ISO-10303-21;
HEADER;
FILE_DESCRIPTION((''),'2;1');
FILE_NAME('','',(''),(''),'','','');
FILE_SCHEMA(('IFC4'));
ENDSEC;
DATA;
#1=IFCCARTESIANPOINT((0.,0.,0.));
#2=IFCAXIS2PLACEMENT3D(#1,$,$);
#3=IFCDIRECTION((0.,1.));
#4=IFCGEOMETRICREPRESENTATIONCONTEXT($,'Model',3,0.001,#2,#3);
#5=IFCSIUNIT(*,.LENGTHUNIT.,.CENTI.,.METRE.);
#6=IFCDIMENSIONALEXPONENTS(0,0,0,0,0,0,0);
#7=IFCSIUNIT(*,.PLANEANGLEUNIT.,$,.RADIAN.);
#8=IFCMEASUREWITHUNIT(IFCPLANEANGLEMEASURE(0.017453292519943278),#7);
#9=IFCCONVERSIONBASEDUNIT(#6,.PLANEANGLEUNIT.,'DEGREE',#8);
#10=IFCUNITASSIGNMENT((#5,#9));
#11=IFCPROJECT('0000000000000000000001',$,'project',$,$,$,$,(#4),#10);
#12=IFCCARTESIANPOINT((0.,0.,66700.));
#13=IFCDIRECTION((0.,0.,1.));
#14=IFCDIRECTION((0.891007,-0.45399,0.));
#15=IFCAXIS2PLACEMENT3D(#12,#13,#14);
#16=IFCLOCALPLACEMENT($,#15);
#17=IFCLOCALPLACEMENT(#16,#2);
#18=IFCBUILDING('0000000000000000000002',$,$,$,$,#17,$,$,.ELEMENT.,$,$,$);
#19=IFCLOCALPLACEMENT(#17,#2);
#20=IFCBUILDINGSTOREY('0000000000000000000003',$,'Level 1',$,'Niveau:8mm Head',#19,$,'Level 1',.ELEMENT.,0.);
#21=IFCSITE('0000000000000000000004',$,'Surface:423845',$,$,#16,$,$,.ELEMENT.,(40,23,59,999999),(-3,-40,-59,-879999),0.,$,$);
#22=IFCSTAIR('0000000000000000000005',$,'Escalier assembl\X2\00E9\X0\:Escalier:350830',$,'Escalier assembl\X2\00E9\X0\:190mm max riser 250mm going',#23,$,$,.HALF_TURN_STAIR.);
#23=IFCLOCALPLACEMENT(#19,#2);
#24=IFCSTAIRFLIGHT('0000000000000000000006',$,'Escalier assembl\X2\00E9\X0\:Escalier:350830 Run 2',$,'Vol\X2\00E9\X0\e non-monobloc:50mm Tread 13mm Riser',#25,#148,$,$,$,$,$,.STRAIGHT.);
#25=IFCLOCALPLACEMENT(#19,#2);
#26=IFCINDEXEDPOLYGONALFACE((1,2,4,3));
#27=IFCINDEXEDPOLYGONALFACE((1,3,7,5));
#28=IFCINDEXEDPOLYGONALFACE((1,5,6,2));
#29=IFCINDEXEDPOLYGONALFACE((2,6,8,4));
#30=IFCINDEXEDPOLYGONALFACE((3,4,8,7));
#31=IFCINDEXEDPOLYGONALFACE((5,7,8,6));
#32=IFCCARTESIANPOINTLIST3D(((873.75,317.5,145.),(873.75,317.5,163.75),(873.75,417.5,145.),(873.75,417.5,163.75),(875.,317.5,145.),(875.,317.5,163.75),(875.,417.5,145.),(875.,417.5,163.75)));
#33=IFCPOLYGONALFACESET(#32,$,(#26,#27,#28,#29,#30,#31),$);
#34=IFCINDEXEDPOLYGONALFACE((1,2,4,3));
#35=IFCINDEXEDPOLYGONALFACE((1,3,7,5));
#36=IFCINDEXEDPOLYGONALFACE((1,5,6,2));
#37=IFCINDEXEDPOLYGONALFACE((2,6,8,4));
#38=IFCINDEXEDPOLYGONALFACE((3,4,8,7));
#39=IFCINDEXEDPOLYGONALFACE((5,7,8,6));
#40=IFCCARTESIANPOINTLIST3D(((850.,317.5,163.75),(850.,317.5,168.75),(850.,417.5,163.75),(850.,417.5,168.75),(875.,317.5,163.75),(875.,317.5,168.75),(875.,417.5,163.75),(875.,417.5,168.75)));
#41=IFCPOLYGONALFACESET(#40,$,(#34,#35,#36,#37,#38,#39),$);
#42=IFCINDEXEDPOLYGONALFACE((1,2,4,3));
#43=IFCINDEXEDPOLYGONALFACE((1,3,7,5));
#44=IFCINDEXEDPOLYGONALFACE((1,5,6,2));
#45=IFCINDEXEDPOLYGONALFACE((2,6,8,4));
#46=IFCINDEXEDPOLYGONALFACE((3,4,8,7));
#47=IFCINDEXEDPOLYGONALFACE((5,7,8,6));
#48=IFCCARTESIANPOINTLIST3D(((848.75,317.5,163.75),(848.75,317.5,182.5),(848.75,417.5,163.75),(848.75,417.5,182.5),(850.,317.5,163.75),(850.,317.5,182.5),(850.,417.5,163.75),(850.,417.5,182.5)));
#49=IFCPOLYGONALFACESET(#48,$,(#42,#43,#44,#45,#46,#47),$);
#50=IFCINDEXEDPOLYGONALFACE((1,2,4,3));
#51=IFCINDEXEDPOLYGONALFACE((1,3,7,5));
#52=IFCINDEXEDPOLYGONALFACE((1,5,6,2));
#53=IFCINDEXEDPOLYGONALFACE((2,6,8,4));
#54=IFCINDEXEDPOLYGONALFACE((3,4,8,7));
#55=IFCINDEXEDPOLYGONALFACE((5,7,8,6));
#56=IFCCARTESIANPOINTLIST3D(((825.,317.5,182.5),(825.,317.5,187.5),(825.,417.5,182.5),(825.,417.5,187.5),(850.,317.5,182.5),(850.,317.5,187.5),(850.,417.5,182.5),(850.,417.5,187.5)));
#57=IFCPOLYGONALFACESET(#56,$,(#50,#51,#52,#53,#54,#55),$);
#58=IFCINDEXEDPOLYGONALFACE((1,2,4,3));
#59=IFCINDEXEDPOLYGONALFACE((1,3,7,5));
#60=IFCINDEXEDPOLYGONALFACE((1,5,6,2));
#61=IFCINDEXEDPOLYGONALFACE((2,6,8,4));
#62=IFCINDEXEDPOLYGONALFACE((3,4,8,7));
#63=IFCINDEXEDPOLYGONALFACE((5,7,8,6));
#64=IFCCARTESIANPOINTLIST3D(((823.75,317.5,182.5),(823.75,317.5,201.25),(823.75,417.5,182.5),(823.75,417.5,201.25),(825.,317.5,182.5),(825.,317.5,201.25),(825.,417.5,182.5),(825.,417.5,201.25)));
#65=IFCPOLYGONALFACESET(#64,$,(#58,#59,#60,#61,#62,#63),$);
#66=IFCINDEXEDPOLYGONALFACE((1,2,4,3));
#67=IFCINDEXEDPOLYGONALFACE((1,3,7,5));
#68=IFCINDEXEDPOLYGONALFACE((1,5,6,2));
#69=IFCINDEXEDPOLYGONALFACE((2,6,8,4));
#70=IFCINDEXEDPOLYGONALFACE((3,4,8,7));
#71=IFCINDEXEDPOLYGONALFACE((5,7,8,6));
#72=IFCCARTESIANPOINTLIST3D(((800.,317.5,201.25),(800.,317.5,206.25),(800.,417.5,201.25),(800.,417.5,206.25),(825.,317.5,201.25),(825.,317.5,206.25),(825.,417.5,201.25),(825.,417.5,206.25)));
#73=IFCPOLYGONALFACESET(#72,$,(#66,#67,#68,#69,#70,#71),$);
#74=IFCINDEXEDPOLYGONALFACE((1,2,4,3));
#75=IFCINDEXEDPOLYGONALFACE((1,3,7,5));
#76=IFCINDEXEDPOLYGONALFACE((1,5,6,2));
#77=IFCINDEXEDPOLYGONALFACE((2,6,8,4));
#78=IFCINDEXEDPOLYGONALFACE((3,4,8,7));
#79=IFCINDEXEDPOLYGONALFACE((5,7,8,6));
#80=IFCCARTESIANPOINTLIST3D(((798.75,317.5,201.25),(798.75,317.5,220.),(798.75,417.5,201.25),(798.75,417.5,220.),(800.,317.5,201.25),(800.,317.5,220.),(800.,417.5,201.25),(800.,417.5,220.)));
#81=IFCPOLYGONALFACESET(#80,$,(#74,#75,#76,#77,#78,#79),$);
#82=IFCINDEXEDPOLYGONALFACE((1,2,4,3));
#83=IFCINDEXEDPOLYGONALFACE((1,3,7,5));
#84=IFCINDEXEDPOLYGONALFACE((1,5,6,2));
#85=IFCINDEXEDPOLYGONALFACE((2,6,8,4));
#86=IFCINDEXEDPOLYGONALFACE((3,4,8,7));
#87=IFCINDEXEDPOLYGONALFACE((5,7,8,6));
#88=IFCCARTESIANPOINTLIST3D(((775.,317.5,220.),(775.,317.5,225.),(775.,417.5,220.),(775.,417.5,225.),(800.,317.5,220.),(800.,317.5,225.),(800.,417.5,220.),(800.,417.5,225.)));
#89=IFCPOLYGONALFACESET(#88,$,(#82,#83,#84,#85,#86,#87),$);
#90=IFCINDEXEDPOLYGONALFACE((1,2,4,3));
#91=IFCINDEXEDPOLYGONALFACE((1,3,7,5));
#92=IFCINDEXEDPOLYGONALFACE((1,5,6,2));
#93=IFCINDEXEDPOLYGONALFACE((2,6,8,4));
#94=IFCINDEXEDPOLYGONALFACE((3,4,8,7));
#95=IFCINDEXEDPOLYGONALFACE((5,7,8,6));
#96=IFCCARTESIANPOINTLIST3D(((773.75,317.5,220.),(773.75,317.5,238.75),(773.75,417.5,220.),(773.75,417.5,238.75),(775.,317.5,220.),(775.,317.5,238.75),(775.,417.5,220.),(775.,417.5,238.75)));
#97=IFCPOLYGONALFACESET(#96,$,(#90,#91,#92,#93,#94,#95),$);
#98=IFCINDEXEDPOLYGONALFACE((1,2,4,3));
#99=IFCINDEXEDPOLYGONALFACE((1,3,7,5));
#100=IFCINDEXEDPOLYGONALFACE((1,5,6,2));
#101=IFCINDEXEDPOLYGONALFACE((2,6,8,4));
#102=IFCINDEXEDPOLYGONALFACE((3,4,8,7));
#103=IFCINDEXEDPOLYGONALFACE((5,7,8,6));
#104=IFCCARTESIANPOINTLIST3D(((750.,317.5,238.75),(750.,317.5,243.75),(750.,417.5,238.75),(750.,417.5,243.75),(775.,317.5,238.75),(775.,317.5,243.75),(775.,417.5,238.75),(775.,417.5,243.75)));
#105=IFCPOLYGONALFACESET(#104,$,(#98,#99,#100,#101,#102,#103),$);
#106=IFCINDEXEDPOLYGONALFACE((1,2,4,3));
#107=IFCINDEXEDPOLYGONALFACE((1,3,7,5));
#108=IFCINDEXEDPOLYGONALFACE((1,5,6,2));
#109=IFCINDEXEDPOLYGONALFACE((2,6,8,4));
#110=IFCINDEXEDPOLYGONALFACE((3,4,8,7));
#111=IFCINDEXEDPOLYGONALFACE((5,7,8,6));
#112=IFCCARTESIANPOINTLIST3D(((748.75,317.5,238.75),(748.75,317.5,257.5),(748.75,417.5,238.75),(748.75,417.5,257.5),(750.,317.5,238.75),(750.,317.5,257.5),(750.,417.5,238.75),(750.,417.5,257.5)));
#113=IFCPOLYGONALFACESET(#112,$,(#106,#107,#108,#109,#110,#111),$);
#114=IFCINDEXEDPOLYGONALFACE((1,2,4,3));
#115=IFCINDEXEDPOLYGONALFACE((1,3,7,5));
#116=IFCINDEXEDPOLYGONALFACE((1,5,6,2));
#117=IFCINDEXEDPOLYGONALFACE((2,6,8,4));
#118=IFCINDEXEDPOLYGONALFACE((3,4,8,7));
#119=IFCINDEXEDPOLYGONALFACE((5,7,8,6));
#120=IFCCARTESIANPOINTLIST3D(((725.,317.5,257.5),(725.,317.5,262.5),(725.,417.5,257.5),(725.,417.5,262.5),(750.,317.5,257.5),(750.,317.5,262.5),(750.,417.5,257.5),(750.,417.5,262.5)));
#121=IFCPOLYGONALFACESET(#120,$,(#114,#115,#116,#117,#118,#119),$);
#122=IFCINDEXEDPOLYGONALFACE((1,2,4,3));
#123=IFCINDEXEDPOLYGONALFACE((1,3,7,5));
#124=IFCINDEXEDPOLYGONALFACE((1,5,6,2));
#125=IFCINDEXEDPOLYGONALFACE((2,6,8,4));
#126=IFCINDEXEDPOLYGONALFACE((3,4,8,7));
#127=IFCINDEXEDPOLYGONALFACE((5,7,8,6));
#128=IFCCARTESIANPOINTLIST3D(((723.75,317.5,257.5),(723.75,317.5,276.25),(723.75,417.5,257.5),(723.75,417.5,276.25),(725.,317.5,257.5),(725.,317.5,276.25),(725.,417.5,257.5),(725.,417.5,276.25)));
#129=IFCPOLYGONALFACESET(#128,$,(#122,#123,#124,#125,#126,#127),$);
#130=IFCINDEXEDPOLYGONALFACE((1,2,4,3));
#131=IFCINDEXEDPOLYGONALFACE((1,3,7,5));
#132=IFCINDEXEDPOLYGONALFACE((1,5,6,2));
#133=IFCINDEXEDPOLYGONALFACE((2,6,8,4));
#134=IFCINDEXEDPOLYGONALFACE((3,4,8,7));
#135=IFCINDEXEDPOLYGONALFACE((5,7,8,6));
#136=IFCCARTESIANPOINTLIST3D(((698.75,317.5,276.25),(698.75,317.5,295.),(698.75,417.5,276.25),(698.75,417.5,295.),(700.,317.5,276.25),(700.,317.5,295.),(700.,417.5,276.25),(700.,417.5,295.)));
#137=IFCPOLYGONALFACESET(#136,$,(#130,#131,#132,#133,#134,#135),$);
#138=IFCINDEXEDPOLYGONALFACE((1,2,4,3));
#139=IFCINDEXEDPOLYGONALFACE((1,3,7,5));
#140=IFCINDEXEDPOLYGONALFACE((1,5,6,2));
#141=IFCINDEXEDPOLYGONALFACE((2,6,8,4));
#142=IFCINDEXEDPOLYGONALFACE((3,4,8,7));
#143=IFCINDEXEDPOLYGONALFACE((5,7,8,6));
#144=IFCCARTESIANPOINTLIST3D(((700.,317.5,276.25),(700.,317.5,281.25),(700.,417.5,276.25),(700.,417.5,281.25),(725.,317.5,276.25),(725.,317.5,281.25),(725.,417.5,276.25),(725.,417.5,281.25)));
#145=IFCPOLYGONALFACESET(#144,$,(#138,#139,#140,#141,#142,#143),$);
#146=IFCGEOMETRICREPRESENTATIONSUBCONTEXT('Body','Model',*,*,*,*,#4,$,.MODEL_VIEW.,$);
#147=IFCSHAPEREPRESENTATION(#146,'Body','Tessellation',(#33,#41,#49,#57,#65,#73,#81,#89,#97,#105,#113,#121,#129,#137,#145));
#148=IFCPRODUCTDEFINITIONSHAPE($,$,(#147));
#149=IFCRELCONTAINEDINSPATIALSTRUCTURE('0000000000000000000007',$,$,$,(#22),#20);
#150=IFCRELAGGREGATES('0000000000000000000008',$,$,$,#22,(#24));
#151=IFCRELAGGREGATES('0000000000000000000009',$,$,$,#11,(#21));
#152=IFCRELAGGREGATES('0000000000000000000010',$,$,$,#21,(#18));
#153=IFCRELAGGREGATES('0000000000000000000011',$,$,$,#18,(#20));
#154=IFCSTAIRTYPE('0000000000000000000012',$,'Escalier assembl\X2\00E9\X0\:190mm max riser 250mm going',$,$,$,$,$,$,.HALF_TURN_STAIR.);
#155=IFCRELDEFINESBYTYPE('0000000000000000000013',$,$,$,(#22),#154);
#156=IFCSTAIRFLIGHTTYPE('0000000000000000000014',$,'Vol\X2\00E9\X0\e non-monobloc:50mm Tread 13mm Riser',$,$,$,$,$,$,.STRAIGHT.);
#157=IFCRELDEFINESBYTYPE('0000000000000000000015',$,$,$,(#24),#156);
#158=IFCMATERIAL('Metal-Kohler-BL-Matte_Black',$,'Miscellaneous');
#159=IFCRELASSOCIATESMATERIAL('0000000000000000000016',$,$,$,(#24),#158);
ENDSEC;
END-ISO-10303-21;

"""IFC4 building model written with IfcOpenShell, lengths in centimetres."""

from ifc_helpers import new_model, entity, si_unit, converted_unit, direction, frame, frame_2d, origin, origin_2d_with_axis, place, context, subcontext, project, spatial, rectangle, extrude, material, type_object, element, aggregate, save


model = new_model("IFC4")

# Units and contexts
model_context = context("Model", 3, precision=0.001, world=origin(), true_north=direction((0.0, 1.0)))
body_context = subcontext(model_context, "Body", "Model", "MODEL_VIEW")
ifc_project = project(units=[si_unit("LENGTHUNIT", "METRE", prefix="CENTI"), converted_unit("PLANEANGLEUNIT", "DEGREE", entity("IfcPlaneAngleMeasure", 0.017453292519943278), si_unit("PLANEANGLEUNIT", "RADIAN"), dimensions=[0, 0, 0, 0, 0, 0, 0])], contexts=[model_context])

# Site, building, storey
site_placement = place(None, frame((0.0, 0.0, 66700.0), z_axis=(0.0, 0.0, 1.0), x_axis=(0.891007, -0.45399, 0.0)))
site = spatial("IfcSite", under=ifc_project, at=site_placement, Name="Surface:423845", CompositionType="ELEMENT", RefLatitude=(40, 23, 59, 999999), RefLongitude=(-3, -40, -59, -879999), RefElevation=0.0)
building_placement = place(site_placement, origin())
building = spatial("IfcBuilding", under=site, at=building_placement, CompositionType="ELEMENT")
storey_placement = place(building_placement, origin())
storey = spatial("IfcBuildingStorey", under=building, at=storey_placement, Name="Level 1", ObjectType="Niveau:8mm Head", LongName="Level 1", CompositionType="ELEMENT", Elevation=0.0)

# Shared definitions
ifc_material_1 = material(Name="Metal-Kohler-BL-Matte_Black", Category="Miscellaneous")

# Stair
stair_type = type_object("IfcStairType", Name="Escalier assemblé:190mm max riser 250mm going", PredefinedType="HALF_TURN_STAIR")
stair_placement = place(storey_placement, origin())
stair = element("IfcStair", 1, at=stair_placement, inside=storey, type_object=stair_type, Name="Escalier assemblé:Escalier:350830", ObjectType="Escalier assemblé:190mm max riser 250mm going", PredefinedType="HALF_TURN_STAIR")

# Stair flight
stair_flight_type = type_object("IfcStairFlightType", Name="Volée non-monobloc:50mm Tread 13mm Riser", PredefinedType="STRAIGHT")
stair_flight_1_placement = place(stair_placement, origin())
stair_flight_1 = element("IfcStairFlight", 2, at=stair_flight_1_placement, type_object=stair_flight_type, material=ifc_material_1, Name="Escalier assemblé:Escalier:350830 Run 2", ObjectType="Volée non-monobloc:50mm Tread 13mm Riser", PredefinedType="STRAIGHT", context=body_context, shape_type="SweptSolid", body=[
    extrude(rectangle(XDim=100.0, YDim=1.25, at=frame_2d((0.0, 0.0), x_axis=(1.0, 0.0))), frame((874.38, 367.5, 145.0), z_axis=(0.0, 0.0, 1.0), x_axis=(0.0, -1.0, 0.0)), (0.0, 0.0, 1.0), 18.75),
    extrude(rectangle(XDim=25.0, YDim=100.0, at=frame_2d((0.0, 0.0), x_axis=(1.0, 0.0))), frame((862.5, 367.5, 163.75)), (0.0, 0.0, 1.0), 5.0),
    extrude(rectangle(XDim=100.0, YDim=1.25, at=frame_2d((0.0, 0.0), x_axis=(1.0, 0.0))), frame((849.38, 367.5, 163.75), z_axis=(0.0, 0.0, 1.0), x_axis=(0.0, -1.0, 0.0)), (0.0, 0.0, 1.0), 18.75),
    extrude(rectangle(XDim=25.0, YDim=100.0, at=frame_2d((0.0, 0.0), x_axis=(1.0, 0.0))), frame((837.5, 367.5, 182.5)), (0.0, 0.0, 1.0), 5.0),
    extrude(rectangle(XDim=100.0, YDim=1.25, at=frame_2d((0.0, 0.0), x_axis=(1.0, 0.0))), frame((824.38, 367.5, 182.5), z_axis=(0.0, 0.0, 1.0), x_axis=(0.0, -1.0, 0.0)), (0.0, 0.0, 1.0), 18.75),
    extrude(rectangle(XDim=25.0, YDim=100.0, at=frame_2d((0.0, 0.0), x_axis=(1.0, 0.0))), frame((812.5, 367.5, 201.25)), (0.0, 0.0, 1.0), 5.0),
    extrude(rectangle(XDim=100.0, YDim=1.25, at=frame_2d((0.0, 0.0), x_axis=(1.0, 0.0))), frame((799.38, 367.5, 201.25), z_axis=(0.0, 0.0, 1.0), x_axis=(0.0, -1.0, 0.0)), (0.0, 0.0, 1.0), 18.75),
    extrude(rectangle(XDim=25.0, YDim=100.0, at=origin_2d_with_axis()), frame((787.5, 367.5, 220.0)), (0.0, 0.0, 1.0), 5.0),
    extrude(rectangle(XDim=100.0, YDim=1.25, at=frame_2d((0.0, 0.0), x_axis=(1.0, 0.0))), frame((774.38, 367.5, 220.0), z_axis=(0.0, 0.0, 1.0), x_axis=(0.0, -1.0, 0.0)), (0.0, 0.0, 1.0), 18.75),
    extrude(rectangle(XDim=25.0, YDim=100.0, at=frame_2d((0.0, 0.0), x_axis=(1.0, 0.0))), frame((762.5, 367.5, 238.75)), (0.0, 0.0, 1.0), 5.0),
    extrude(rectangle(XDim=100.0, YDim=1.25, at=frame_2d((0.0, 0.0), x_axis=(1.0, 0.0))), frame((749.38, 367.5, 238.75), z_axis=(0.0, 0.0, 1.0), x_axis=(0.0, -1.0, 0.0)), (0.0, 0.0, 1.0), 18.75),
    extrude(rectangle(XDim=25.0, YDim=100.0, at=origin_2d_with_axis()), frame((737.5, 367.5, 257.5)), (0.0, 0.0, 1.0), 5.0),
    extrude(rectangle(XDim=100.0, YDim=1.25, at=frame_2d((0.0, 0.0), x_axis=(1.0, 0.0))), frame((724.38, 367.5, 257.5), z_axis=(0.0, 0.0, 1.0), x_axis=(0.0, -1.0, 0.0)), (0.0, 0.0, 1.0), 18.75),
    extrude(rectangle(XDim=100.0, YDim=1.25, at=frame_2d((0.0, 0.0), x_axis=(1.0, 0.0))), frame((699.38, 367.5, 276.25), z_axis=(0.0, 0.0, 1.0), x_axis=(0.0, -1.0, 0.0)), (0.0, 0.0, 1.0), 18.75),
    extrude(rectangle(XDim=25.0, YDim=100.0, at=origin_2d_with_axis()), frame((712.5, 367.5, 276.25)), (0.0, 0.0, 1.0), 5.0),
])
aggregate(stair, [stair_flight_1])

save(model, "model.ifc")
